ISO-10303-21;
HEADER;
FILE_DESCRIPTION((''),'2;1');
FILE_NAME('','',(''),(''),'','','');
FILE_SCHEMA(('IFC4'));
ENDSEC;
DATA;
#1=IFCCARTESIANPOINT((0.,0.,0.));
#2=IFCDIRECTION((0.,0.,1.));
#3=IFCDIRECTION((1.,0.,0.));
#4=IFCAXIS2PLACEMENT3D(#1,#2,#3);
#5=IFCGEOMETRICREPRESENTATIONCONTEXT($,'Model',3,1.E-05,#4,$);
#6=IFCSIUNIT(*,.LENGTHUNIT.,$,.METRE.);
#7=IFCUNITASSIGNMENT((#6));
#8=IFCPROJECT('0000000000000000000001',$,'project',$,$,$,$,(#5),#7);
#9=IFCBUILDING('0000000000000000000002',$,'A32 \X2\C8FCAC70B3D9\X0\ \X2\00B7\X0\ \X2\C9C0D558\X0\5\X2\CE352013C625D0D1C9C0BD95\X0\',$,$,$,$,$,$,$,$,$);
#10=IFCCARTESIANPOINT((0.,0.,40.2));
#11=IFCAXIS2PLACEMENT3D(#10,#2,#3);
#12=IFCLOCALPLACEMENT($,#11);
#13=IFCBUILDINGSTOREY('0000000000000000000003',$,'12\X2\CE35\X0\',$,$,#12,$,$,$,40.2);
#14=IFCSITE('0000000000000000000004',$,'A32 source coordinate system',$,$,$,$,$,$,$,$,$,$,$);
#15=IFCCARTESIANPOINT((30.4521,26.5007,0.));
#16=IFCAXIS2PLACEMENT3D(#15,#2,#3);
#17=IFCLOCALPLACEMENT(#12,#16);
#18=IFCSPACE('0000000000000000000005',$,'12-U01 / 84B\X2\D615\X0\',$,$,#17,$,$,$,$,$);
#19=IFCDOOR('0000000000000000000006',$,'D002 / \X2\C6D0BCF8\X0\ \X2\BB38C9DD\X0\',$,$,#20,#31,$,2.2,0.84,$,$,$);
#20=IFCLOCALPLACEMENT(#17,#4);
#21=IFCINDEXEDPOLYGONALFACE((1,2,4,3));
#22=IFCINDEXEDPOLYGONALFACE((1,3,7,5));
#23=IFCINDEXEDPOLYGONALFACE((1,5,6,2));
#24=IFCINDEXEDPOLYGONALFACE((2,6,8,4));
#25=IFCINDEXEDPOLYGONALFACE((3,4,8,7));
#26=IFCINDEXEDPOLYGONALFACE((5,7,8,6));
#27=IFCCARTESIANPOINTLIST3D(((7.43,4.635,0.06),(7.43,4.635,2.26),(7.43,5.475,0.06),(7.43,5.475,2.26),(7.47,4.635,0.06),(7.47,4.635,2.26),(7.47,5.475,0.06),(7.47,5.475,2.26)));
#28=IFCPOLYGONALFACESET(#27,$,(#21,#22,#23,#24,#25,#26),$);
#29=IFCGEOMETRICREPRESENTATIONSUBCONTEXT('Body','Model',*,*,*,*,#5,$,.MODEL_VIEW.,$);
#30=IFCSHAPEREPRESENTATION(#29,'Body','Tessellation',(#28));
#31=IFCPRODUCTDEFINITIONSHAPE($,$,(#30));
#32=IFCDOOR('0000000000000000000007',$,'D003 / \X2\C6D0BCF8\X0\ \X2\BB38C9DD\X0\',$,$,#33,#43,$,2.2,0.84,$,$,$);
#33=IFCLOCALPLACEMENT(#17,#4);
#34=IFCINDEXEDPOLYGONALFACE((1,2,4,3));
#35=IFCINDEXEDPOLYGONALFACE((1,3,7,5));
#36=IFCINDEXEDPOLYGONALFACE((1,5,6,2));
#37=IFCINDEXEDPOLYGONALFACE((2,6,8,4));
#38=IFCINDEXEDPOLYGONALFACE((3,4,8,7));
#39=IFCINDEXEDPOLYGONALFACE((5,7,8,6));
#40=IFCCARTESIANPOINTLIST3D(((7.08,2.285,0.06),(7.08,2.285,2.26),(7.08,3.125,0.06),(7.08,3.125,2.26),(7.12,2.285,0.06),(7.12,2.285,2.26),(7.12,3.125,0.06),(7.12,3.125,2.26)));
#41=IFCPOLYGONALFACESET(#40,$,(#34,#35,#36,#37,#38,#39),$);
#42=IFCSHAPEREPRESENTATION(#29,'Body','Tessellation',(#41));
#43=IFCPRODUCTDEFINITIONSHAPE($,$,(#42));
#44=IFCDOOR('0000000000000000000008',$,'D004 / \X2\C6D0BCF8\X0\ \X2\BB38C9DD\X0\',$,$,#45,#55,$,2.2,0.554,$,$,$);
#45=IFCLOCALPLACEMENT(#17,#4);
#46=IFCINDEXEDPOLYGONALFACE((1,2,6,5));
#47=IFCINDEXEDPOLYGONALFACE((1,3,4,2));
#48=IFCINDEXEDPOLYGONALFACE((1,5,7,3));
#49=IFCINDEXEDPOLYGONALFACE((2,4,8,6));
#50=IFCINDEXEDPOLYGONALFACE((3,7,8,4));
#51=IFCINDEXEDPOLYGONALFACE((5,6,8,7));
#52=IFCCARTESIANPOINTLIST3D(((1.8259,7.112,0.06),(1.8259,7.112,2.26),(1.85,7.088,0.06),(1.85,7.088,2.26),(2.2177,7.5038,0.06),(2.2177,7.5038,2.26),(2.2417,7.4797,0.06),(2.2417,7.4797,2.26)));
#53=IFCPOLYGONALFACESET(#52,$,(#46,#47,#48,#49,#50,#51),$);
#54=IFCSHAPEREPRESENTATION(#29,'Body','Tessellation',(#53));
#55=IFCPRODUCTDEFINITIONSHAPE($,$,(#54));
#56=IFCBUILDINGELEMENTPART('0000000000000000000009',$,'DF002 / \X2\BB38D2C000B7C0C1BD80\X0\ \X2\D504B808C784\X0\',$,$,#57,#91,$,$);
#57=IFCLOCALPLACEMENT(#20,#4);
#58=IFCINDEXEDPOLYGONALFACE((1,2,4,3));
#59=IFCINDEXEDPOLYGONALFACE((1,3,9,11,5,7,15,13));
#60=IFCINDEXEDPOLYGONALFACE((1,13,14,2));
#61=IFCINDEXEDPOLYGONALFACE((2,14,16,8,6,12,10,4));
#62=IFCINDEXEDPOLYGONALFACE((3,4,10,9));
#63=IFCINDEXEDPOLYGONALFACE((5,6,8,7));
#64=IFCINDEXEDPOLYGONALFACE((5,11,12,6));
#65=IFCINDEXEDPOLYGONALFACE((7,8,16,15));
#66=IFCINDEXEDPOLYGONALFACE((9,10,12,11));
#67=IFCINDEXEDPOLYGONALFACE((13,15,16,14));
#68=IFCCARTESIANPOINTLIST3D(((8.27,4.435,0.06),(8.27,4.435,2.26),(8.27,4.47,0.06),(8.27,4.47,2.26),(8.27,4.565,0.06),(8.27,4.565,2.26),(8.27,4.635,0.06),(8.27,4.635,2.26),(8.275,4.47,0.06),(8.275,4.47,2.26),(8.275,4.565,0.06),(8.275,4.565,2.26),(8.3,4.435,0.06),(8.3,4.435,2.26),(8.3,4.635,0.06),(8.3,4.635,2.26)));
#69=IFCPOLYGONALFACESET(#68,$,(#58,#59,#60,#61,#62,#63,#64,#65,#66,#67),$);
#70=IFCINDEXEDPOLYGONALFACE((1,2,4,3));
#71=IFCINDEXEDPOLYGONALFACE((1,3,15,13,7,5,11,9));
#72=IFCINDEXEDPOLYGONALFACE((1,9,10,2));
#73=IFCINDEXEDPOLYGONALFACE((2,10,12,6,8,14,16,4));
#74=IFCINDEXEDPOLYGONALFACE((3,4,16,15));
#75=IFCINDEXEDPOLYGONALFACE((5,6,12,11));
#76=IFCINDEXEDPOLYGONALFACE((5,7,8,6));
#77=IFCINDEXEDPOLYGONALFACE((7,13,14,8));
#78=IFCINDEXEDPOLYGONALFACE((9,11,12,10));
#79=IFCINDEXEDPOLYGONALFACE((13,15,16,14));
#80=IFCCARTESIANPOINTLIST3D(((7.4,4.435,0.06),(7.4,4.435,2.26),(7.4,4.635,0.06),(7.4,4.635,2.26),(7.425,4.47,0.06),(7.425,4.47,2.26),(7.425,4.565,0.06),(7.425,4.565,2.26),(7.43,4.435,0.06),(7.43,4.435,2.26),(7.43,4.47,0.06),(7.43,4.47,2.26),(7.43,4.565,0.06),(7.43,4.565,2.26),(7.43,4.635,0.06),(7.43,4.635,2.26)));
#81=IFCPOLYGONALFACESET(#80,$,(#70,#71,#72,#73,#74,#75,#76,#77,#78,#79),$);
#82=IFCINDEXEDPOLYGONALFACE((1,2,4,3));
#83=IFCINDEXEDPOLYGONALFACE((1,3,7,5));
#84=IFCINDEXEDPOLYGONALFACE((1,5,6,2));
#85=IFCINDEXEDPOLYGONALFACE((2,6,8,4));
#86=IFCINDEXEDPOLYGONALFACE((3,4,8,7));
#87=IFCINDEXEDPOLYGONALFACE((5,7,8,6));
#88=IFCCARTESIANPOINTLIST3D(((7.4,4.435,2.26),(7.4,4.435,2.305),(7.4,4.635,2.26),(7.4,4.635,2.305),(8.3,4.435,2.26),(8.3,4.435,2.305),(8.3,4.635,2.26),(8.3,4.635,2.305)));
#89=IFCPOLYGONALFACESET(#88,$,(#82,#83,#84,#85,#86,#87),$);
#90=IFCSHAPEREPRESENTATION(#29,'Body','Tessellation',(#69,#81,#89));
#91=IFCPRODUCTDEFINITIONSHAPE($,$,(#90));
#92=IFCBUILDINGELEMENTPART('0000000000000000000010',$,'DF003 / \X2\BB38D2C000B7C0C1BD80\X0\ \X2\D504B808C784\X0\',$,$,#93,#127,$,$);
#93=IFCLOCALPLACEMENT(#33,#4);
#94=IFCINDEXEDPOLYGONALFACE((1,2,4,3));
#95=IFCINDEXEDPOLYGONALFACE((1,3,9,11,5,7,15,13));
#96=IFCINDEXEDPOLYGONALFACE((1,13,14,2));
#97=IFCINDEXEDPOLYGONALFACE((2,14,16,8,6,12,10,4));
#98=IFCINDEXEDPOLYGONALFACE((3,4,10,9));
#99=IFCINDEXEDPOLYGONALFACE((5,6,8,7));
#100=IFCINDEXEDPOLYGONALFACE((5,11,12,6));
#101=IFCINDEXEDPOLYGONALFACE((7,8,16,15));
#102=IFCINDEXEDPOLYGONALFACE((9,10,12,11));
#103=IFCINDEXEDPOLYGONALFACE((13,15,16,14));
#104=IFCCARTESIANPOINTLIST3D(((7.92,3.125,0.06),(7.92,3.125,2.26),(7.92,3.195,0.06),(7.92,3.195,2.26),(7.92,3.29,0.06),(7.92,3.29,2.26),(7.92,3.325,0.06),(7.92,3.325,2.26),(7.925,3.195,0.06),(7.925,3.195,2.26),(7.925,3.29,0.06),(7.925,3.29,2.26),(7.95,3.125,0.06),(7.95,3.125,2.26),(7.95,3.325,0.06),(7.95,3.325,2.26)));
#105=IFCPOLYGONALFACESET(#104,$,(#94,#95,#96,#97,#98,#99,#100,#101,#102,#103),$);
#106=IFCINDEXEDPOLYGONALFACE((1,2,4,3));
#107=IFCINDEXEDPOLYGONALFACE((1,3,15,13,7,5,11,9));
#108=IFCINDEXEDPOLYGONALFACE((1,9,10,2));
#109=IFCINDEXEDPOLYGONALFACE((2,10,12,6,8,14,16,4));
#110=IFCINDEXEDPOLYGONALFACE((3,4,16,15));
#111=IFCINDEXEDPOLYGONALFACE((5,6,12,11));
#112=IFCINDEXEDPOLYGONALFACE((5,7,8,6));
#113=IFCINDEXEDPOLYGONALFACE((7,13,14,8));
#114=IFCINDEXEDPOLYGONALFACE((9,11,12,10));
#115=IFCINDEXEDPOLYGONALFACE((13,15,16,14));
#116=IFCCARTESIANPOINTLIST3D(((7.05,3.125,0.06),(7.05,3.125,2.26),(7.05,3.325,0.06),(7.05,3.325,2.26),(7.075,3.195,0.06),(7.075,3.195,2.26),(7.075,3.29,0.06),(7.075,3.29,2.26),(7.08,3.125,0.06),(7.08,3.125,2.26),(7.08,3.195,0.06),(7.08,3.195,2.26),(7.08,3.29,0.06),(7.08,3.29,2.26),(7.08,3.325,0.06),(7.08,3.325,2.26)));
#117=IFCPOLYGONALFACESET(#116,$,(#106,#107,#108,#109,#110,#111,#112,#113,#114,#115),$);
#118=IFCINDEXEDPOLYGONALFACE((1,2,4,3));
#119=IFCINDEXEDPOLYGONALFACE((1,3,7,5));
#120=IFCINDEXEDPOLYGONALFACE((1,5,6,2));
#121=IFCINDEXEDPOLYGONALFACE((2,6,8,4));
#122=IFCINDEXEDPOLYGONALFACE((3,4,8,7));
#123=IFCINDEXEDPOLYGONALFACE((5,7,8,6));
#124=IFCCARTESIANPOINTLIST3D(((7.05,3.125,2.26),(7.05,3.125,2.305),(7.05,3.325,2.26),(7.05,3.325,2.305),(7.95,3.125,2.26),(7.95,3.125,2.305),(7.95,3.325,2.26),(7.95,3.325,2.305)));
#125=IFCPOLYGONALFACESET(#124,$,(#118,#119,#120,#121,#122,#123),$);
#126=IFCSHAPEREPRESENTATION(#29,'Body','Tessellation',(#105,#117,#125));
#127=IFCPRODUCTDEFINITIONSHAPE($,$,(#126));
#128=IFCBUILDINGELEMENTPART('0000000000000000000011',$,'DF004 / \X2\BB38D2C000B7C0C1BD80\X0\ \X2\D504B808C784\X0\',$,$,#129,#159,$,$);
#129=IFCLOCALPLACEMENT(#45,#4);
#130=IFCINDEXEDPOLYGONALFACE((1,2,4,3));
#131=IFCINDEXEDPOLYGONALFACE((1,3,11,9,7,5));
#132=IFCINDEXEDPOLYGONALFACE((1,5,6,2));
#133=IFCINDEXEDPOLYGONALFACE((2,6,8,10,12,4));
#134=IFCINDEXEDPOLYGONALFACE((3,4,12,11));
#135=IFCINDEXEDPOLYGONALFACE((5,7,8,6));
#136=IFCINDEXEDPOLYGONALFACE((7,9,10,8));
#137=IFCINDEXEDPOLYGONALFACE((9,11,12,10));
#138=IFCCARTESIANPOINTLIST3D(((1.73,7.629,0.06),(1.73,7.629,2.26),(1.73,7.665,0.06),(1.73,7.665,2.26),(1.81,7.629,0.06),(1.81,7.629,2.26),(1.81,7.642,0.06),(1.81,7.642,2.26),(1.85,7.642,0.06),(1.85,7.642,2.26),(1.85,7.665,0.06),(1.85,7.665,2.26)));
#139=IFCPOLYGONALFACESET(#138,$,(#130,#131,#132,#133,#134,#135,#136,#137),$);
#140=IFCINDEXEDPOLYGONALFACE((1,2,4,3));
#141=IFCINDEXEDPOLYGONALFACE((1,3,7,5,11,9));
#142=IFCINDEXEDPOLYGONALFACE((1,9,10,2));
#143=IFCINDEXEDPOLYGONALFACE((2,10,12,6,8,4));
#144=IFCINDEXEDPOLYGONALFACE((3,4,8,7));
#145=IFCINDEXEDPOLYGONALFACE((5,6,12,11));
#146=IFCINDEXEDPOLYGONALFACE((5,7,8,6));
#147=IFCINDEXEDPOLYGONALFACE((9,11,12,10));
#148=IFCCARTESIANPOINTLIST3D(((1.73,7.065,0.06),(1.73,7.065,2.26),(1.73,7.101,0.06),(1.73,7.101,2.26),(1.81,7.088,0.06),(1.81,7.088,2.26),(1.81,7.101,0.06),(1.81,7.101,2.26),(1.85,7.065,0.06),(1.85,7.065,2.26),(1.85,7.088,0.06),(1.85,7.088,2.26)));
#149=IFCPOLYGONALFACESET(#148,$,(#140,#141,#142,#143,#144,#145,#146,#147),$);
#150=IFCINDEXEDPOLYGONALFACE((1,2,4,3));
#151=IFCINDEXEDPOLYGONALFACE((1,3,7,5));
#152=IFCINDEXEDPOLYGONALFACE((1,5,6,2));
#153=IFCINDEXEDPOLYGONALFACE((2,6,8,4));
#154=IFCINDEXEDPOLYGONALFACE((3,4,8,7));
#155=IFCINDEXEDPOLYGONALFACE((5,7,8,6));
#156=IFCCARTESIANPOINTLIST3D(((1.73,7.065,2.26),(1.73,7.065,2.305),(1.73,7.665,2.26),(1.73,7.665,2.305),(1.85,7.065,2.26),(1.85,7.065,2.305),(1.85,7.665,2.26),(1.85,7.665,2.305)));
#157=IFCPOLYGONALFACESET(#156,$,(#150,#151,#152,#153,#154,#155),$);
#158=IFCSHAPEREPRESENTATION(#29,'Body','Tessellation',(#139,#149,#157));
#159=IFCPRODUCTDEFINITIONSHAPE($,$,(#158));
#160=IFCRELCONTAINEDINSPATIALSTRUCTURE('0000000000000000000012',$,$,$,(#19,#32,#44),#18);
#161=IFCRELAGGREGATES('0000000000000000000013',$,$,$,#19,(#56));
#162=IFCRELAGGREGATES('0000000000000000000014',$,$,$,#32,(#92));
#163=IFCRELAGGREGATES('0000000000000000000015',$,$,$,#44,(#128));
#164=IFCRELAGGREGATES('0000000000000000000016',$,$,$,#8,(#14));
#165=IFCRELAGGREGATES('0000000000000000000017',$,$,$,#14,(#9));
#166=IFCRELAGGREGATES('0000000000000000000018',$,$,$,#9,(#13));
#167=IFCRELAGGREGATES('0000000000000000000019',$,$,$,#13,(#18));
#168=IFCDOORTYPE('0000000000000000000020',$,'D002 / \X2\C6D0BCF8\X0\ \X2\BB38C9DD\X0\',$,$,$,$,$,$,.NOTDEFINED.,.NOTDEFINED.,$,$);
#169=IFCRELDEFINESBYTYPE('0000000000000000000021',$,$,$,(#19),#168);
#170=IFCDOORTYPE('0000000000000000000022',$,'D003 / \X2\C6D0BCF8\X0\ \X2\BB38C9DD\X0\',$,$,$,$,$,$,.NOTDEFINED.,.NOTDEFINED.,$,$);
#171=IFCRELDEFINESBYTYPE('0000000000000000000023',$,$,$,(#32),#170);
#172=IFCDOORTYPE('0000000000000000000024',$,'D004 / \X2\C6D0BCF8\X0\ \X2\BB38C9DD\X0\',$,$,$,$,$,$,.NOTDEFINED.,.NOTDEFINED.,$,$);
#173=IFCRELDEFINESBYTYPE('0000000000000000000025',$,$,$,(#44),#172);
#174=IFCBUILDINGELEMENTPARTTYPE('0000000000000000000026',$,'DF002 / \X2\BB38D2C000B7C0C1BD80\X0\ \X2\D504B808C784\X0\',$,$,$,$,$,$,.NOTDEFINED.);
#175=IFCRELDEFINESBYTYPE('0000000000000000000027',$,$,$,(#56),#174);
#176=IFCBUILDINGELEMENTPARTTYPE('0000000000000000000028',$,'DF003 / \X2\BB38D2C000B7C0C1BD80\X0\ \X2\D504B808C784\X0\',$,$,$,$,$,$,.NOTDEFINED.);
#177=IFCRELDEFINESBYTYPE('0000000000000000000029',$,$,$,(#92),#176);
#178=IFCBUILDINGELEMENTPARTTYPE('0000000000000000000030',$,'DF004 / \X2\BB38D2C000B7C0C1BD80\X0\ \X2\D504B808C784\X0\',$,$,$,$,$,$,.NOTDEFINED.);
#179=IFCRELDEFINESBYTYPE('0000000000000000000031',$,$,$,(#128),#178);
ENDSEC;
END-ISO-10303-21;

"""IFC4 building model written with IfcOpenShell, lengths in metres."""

from ifc_helpers import new_model, si_unit, frame, origin, origin_with_axes, place, context, subcontext, project, spatial, polyline, outline, extrude, source, transform, mapped, type_object, type_shapes, element, aggregate, save


model = new_model("IFC4")

# Units and contexts
model_context = context("Model", 3, precision=1e-05, world=origin_with_axes())
body_context = subcontext(model_context, "Body", "Model", "MODEL_VIEW")
ifc_project = project(units=[si_unit("LENGTHUNIT", "METRE")], contexts=[model_context])

# Site, building, storey, space
storey_placement = place(None, frame((0.0, 0.0, 40.2), z_axis=(0.0, 0.0, 1.0), x_axis=(1.0, 0.0, 0.0)))
space_placement = place(storey_placement, frame((30.4521, 26.5007, 0.0), z_axis=(0.0, 0.0, 1.0), x_axis=(1.0, 0.0, 0.0)))
site = spatial("IfcSite", under=ifc_project, Name="A32 source coordinate system")
building = spatial("IfcBuilding", under=site, Name="A32 주거동 · 지하5층–옥탑지붕")
storey = spatial("IfcBuildingStorey", under=building, at=storey_placement, Name="12층", Elevation=40.2)
space = spatial("IfcSpace", under=storey, at=space_placement, Name="12-U01 / 84B형")

# Doors
door_type_1 = type_object("IfcDoorType", Name="D002 / 원본 문짝", OperationType="NOTDEFINED", PredefinedType="NOTDEFINED")
shared_shape_1 = source(origin(), body_context, "Body", "SweptSolid", [
    extrude(outline(polyline([(7.43, 4.635), (7.43, 5.475), (7.47, 5.475), (7.47, 4.635), (7.43, 4.635)])), frame((0.0, 0.0, 0.06)), (0.0, 0.0, 1.0), 2.2),
])
type_shapes(door_type_1, [shared_shape_1])
door_1_placement = place(space_placement, origin_with_axes())
door_1 = element("IfcDoor", 1, at=door_1_placement, inside=space, type_object=door_type_1, Name="D002 / 원본 문짝", OverallHeight=2.2, OverallWidth=0.84, context=body_context, shape_type="MappedRepresentation", body=[
    mapped(shared_shape_1, transform((0.0, 0.0, 0.0), scale=1.0)),
])
door_type_2 = type_object("IfcDoorType", Name="D003 / 원본 문짝", OperationType="NOTDEFINED", PredefinedType="NOTDEFINED")
shared_shape_2 = source(origin(), body_context, "Body", "SweptSolid", [
    extrude(outline(polyline([(7.12, 2.285), (7.08, 2.285), (7.08, 3.125), (7.12, 3.125), (7.12, 2.285)])), frame((0.0, 0.0, 0.06)), (0.0, 0.0, 1.0), 2.2),
])
type_shapes(door_type_2, [shared_shape_2])
door_2_placement = place(space_placement, origin_with_axes())
door_2 = element("IfcDoor", 2, at=door_2_placement, inside=space, type_object=door_type_2, Name="D003 / 원본 문짝", OverallHeight=2.2, OverallWidth=0.84, context=body_context, shape_type="MappedRepresentation", body=[
    mapped(shared_shape_2, transform((0.0, 0.0, 0.0), scale=1.0)),
])
door_type_3 = type_object("IfcDoorType", Name="D004 / 원본 문짝", OperationType="NOTDEFINED", PredefinedType="NOTDEFINED")
shared_shape_3 = source(origin(), body_context, "Body", "SweptSolid", [
    extrude(outline(polyline([(2.2177, 7.5038), (2.2417, 7.4797), (1.85, 7.088), (1.8259, 7.112), (2.2177, 7.5038)])), frame((0.0, 0.0, 0.06)), (0.0, 0.0, 1.0), 2.2),
])
type_shapes(door_type_3, [shared_shape_3])
door_3_placement = place(space_placement, origin_with_axes())
door_3 = element("IfcDoor", 3, at=door_3_placement, inside=space, type_object=door_type_3, Name="D004 / 원본 문짝", OverallHeight=2.2, OverallWidth=0.554, context=body_context, shape_type="MappedRepresentation", body=[
    mapped(shared_shape_3, transform((0.0, 0.0, 0.0), scale=1.0)),
])

# Building element parts
building_element_part_type_1 = type_object("IfcBuildingElementPartType", Name="DF002 / 문틀·상부 프레임", PredefinedType="NOTDEFINED")
shared_shape_4 = source(origin(), body_context, "Body", "SweptSolid", [
    extrude(outline(polyline([(8.3, 4.435), (8.27, 4.435), (8.27, 4.47), (8.275, 4.47), (8.275, 4.565), (8.27, 4.565), (8.27, 4.635), (8.3, 4.635), (8.3, 4.435)])), frame((0.0, 0.0, 0.06)), (0.0, 0.0, 1.0), 2.2),
    extrude(outline(polyline([(7.43, 4.635), (7.43, 4.565), (7.425, 4.565), (7.425, 4.47), (7.43, 4.47), (7.43, 4.435), (7.4, 4.435), (7.4, 4.635), (7.43, 4.635)])), frame((0.0, 0.0, 0.06)), (0.0, 0.0, 1.0), 2.2),
    extrude(outline(polyline([(7.4, 4.435), (7.4, 4.635), (8.3, 4.635), (8.3, 4.435), (7.4, 4.435)])), frame((0.0, 0.0, 2.26)), (0.0, 0.0, 1.0), 0.045),
])
type_shapes(building_element_part_type_1, [shared_shape_4])
building_element_part_1_placement = place(door_1_placement, origin_with_axes())
building_element_part_1 = element("IfcBuildingElementPart", 4, at=building_element_part_1_placement, type_object=building_element_part_type_1, Name="DF002 / 문틀·상부 프레임", context=body_context, shape_type="MappedRepresentation", body=[
    mapped(shared_shape_4, transform((0.0, 0.0, 0.0), scale=1.0)),
])
aggregate(door_1, [building_element_part_1])
building_element_part_type_2 = type_object("IfcBuildingElementPartType", Name="DF003 / 문틀·상부 프레임", PredefinedType="NOTDEFINED")
shared_shape_5 = source(origin(), body_context, "Body", "SweptSolid", [
    extrude(outline(polyline([(7.92, 3.125), (7.92, 3.195), (7.925, 3.195), (7.925, 3.29), (7.92, 3.29), (7.92, 3.325), (7.95, 3.325), (7.95, 3.125), (7.92, 3.125)])), frame((0.0, 0.0, 0.06)), (0.0, 0.0, 1.0), 2.2),
    extrude(outline(polyline([(7.05, 3.325), (7.08, 3.325), (7.08, 3.29), (7.075, 3.29), (7.075, 3.195), (7.08, 3.195), (7.08, 3.125), (7.05, 3.125), (7.05, 3.325)])), frame((0.0, 0.0, 0.06)), (0.0, 0.0, 1.0), 2.2),
    extrude(outline(polyline([(7.05, 3.125), (7.05, 3.325), (7.95, 3.325), (7.95, 3.125), (7.05, 3.125)])), frame((0.0, 0.0, 2.26)), (0.0, 0.0, 1.0), 0.045),
])
type_shapes(building_element_part_type_2, [shared_shape_5])
building_element_part_2_placement = place(door_2_placement, origin_with_axes())
building_element_part_2 = element("IfcBuildingElementPart", 5, at=building_element_part_2_placement, type_object=building_element_part_type_2, Name="DF003 / 문틀·상부 프레임", context=body_context, shape_type="MappedRepresentation", body=[
    mapped(shared_shape_5, transform((0.0, 0.0, 0.0), scale=1.0)),
])
aggregate(door_2, [building_element_part_2])
building_element_part_type_3 = type_object("IfcBuildingElementPartType", Name="DF004 / 문틀·상부 프레임", PredefinedType="NOTDEFINED")
shared_shape_6 = source(origin(), body_context, "Body", "SweptSolid", [
    extrude(outline(polyline([(1.85, 7.665), (1.85, 7.642), (1.81, 7.642), (1.81, 7.629), (1.73, 7.629), (1.73, 7.665), (1.85, 7.665)])), frame((0.0, 0.0, 0.06)), (0.0, 0.0, 1.0), 2.2),
    extrude(outline(polyline([(1.73, 7.101), (1.81, 7.101), (1.81, 7.088), (1.85, 7.088), (1.85, 7.065), (1.73, 7.065), (1.73, 7.101)])), frame((0.0, 0.0, 0.06)), (0.0, 0.0, 1.0), 2.2),
    extrude(outline(polyline([(1.73, 7.065), (1.73, 7.665), (1.85, 7.665), (1.85, 7.065), (1.73, 7.065)])), frame((0.0, 0.0, 2.26)), (0.0, 0.0, 1.0), 0.045),
])
type_shapes(building_element_part_type_3, [shared_shape_6])
building_element_part_3_placement = place(door_3_placement, origin_with_axes())
building_element_part_3 = element("IfcBuildingElementPart", 6, at=building_element_part_3_placement, type_object=building_element_part_type_3, Name="DF004 / 문틀·상부 프레임", context=body_context, shape_type="MappedRepresentation", body=[
    mapped(shared_shape_6, transform((0.0, 0.0, 0.0), scale=1.0)),
])
aggregate(door_3, [building_element_part_3])

save(model, "model.ifc")
